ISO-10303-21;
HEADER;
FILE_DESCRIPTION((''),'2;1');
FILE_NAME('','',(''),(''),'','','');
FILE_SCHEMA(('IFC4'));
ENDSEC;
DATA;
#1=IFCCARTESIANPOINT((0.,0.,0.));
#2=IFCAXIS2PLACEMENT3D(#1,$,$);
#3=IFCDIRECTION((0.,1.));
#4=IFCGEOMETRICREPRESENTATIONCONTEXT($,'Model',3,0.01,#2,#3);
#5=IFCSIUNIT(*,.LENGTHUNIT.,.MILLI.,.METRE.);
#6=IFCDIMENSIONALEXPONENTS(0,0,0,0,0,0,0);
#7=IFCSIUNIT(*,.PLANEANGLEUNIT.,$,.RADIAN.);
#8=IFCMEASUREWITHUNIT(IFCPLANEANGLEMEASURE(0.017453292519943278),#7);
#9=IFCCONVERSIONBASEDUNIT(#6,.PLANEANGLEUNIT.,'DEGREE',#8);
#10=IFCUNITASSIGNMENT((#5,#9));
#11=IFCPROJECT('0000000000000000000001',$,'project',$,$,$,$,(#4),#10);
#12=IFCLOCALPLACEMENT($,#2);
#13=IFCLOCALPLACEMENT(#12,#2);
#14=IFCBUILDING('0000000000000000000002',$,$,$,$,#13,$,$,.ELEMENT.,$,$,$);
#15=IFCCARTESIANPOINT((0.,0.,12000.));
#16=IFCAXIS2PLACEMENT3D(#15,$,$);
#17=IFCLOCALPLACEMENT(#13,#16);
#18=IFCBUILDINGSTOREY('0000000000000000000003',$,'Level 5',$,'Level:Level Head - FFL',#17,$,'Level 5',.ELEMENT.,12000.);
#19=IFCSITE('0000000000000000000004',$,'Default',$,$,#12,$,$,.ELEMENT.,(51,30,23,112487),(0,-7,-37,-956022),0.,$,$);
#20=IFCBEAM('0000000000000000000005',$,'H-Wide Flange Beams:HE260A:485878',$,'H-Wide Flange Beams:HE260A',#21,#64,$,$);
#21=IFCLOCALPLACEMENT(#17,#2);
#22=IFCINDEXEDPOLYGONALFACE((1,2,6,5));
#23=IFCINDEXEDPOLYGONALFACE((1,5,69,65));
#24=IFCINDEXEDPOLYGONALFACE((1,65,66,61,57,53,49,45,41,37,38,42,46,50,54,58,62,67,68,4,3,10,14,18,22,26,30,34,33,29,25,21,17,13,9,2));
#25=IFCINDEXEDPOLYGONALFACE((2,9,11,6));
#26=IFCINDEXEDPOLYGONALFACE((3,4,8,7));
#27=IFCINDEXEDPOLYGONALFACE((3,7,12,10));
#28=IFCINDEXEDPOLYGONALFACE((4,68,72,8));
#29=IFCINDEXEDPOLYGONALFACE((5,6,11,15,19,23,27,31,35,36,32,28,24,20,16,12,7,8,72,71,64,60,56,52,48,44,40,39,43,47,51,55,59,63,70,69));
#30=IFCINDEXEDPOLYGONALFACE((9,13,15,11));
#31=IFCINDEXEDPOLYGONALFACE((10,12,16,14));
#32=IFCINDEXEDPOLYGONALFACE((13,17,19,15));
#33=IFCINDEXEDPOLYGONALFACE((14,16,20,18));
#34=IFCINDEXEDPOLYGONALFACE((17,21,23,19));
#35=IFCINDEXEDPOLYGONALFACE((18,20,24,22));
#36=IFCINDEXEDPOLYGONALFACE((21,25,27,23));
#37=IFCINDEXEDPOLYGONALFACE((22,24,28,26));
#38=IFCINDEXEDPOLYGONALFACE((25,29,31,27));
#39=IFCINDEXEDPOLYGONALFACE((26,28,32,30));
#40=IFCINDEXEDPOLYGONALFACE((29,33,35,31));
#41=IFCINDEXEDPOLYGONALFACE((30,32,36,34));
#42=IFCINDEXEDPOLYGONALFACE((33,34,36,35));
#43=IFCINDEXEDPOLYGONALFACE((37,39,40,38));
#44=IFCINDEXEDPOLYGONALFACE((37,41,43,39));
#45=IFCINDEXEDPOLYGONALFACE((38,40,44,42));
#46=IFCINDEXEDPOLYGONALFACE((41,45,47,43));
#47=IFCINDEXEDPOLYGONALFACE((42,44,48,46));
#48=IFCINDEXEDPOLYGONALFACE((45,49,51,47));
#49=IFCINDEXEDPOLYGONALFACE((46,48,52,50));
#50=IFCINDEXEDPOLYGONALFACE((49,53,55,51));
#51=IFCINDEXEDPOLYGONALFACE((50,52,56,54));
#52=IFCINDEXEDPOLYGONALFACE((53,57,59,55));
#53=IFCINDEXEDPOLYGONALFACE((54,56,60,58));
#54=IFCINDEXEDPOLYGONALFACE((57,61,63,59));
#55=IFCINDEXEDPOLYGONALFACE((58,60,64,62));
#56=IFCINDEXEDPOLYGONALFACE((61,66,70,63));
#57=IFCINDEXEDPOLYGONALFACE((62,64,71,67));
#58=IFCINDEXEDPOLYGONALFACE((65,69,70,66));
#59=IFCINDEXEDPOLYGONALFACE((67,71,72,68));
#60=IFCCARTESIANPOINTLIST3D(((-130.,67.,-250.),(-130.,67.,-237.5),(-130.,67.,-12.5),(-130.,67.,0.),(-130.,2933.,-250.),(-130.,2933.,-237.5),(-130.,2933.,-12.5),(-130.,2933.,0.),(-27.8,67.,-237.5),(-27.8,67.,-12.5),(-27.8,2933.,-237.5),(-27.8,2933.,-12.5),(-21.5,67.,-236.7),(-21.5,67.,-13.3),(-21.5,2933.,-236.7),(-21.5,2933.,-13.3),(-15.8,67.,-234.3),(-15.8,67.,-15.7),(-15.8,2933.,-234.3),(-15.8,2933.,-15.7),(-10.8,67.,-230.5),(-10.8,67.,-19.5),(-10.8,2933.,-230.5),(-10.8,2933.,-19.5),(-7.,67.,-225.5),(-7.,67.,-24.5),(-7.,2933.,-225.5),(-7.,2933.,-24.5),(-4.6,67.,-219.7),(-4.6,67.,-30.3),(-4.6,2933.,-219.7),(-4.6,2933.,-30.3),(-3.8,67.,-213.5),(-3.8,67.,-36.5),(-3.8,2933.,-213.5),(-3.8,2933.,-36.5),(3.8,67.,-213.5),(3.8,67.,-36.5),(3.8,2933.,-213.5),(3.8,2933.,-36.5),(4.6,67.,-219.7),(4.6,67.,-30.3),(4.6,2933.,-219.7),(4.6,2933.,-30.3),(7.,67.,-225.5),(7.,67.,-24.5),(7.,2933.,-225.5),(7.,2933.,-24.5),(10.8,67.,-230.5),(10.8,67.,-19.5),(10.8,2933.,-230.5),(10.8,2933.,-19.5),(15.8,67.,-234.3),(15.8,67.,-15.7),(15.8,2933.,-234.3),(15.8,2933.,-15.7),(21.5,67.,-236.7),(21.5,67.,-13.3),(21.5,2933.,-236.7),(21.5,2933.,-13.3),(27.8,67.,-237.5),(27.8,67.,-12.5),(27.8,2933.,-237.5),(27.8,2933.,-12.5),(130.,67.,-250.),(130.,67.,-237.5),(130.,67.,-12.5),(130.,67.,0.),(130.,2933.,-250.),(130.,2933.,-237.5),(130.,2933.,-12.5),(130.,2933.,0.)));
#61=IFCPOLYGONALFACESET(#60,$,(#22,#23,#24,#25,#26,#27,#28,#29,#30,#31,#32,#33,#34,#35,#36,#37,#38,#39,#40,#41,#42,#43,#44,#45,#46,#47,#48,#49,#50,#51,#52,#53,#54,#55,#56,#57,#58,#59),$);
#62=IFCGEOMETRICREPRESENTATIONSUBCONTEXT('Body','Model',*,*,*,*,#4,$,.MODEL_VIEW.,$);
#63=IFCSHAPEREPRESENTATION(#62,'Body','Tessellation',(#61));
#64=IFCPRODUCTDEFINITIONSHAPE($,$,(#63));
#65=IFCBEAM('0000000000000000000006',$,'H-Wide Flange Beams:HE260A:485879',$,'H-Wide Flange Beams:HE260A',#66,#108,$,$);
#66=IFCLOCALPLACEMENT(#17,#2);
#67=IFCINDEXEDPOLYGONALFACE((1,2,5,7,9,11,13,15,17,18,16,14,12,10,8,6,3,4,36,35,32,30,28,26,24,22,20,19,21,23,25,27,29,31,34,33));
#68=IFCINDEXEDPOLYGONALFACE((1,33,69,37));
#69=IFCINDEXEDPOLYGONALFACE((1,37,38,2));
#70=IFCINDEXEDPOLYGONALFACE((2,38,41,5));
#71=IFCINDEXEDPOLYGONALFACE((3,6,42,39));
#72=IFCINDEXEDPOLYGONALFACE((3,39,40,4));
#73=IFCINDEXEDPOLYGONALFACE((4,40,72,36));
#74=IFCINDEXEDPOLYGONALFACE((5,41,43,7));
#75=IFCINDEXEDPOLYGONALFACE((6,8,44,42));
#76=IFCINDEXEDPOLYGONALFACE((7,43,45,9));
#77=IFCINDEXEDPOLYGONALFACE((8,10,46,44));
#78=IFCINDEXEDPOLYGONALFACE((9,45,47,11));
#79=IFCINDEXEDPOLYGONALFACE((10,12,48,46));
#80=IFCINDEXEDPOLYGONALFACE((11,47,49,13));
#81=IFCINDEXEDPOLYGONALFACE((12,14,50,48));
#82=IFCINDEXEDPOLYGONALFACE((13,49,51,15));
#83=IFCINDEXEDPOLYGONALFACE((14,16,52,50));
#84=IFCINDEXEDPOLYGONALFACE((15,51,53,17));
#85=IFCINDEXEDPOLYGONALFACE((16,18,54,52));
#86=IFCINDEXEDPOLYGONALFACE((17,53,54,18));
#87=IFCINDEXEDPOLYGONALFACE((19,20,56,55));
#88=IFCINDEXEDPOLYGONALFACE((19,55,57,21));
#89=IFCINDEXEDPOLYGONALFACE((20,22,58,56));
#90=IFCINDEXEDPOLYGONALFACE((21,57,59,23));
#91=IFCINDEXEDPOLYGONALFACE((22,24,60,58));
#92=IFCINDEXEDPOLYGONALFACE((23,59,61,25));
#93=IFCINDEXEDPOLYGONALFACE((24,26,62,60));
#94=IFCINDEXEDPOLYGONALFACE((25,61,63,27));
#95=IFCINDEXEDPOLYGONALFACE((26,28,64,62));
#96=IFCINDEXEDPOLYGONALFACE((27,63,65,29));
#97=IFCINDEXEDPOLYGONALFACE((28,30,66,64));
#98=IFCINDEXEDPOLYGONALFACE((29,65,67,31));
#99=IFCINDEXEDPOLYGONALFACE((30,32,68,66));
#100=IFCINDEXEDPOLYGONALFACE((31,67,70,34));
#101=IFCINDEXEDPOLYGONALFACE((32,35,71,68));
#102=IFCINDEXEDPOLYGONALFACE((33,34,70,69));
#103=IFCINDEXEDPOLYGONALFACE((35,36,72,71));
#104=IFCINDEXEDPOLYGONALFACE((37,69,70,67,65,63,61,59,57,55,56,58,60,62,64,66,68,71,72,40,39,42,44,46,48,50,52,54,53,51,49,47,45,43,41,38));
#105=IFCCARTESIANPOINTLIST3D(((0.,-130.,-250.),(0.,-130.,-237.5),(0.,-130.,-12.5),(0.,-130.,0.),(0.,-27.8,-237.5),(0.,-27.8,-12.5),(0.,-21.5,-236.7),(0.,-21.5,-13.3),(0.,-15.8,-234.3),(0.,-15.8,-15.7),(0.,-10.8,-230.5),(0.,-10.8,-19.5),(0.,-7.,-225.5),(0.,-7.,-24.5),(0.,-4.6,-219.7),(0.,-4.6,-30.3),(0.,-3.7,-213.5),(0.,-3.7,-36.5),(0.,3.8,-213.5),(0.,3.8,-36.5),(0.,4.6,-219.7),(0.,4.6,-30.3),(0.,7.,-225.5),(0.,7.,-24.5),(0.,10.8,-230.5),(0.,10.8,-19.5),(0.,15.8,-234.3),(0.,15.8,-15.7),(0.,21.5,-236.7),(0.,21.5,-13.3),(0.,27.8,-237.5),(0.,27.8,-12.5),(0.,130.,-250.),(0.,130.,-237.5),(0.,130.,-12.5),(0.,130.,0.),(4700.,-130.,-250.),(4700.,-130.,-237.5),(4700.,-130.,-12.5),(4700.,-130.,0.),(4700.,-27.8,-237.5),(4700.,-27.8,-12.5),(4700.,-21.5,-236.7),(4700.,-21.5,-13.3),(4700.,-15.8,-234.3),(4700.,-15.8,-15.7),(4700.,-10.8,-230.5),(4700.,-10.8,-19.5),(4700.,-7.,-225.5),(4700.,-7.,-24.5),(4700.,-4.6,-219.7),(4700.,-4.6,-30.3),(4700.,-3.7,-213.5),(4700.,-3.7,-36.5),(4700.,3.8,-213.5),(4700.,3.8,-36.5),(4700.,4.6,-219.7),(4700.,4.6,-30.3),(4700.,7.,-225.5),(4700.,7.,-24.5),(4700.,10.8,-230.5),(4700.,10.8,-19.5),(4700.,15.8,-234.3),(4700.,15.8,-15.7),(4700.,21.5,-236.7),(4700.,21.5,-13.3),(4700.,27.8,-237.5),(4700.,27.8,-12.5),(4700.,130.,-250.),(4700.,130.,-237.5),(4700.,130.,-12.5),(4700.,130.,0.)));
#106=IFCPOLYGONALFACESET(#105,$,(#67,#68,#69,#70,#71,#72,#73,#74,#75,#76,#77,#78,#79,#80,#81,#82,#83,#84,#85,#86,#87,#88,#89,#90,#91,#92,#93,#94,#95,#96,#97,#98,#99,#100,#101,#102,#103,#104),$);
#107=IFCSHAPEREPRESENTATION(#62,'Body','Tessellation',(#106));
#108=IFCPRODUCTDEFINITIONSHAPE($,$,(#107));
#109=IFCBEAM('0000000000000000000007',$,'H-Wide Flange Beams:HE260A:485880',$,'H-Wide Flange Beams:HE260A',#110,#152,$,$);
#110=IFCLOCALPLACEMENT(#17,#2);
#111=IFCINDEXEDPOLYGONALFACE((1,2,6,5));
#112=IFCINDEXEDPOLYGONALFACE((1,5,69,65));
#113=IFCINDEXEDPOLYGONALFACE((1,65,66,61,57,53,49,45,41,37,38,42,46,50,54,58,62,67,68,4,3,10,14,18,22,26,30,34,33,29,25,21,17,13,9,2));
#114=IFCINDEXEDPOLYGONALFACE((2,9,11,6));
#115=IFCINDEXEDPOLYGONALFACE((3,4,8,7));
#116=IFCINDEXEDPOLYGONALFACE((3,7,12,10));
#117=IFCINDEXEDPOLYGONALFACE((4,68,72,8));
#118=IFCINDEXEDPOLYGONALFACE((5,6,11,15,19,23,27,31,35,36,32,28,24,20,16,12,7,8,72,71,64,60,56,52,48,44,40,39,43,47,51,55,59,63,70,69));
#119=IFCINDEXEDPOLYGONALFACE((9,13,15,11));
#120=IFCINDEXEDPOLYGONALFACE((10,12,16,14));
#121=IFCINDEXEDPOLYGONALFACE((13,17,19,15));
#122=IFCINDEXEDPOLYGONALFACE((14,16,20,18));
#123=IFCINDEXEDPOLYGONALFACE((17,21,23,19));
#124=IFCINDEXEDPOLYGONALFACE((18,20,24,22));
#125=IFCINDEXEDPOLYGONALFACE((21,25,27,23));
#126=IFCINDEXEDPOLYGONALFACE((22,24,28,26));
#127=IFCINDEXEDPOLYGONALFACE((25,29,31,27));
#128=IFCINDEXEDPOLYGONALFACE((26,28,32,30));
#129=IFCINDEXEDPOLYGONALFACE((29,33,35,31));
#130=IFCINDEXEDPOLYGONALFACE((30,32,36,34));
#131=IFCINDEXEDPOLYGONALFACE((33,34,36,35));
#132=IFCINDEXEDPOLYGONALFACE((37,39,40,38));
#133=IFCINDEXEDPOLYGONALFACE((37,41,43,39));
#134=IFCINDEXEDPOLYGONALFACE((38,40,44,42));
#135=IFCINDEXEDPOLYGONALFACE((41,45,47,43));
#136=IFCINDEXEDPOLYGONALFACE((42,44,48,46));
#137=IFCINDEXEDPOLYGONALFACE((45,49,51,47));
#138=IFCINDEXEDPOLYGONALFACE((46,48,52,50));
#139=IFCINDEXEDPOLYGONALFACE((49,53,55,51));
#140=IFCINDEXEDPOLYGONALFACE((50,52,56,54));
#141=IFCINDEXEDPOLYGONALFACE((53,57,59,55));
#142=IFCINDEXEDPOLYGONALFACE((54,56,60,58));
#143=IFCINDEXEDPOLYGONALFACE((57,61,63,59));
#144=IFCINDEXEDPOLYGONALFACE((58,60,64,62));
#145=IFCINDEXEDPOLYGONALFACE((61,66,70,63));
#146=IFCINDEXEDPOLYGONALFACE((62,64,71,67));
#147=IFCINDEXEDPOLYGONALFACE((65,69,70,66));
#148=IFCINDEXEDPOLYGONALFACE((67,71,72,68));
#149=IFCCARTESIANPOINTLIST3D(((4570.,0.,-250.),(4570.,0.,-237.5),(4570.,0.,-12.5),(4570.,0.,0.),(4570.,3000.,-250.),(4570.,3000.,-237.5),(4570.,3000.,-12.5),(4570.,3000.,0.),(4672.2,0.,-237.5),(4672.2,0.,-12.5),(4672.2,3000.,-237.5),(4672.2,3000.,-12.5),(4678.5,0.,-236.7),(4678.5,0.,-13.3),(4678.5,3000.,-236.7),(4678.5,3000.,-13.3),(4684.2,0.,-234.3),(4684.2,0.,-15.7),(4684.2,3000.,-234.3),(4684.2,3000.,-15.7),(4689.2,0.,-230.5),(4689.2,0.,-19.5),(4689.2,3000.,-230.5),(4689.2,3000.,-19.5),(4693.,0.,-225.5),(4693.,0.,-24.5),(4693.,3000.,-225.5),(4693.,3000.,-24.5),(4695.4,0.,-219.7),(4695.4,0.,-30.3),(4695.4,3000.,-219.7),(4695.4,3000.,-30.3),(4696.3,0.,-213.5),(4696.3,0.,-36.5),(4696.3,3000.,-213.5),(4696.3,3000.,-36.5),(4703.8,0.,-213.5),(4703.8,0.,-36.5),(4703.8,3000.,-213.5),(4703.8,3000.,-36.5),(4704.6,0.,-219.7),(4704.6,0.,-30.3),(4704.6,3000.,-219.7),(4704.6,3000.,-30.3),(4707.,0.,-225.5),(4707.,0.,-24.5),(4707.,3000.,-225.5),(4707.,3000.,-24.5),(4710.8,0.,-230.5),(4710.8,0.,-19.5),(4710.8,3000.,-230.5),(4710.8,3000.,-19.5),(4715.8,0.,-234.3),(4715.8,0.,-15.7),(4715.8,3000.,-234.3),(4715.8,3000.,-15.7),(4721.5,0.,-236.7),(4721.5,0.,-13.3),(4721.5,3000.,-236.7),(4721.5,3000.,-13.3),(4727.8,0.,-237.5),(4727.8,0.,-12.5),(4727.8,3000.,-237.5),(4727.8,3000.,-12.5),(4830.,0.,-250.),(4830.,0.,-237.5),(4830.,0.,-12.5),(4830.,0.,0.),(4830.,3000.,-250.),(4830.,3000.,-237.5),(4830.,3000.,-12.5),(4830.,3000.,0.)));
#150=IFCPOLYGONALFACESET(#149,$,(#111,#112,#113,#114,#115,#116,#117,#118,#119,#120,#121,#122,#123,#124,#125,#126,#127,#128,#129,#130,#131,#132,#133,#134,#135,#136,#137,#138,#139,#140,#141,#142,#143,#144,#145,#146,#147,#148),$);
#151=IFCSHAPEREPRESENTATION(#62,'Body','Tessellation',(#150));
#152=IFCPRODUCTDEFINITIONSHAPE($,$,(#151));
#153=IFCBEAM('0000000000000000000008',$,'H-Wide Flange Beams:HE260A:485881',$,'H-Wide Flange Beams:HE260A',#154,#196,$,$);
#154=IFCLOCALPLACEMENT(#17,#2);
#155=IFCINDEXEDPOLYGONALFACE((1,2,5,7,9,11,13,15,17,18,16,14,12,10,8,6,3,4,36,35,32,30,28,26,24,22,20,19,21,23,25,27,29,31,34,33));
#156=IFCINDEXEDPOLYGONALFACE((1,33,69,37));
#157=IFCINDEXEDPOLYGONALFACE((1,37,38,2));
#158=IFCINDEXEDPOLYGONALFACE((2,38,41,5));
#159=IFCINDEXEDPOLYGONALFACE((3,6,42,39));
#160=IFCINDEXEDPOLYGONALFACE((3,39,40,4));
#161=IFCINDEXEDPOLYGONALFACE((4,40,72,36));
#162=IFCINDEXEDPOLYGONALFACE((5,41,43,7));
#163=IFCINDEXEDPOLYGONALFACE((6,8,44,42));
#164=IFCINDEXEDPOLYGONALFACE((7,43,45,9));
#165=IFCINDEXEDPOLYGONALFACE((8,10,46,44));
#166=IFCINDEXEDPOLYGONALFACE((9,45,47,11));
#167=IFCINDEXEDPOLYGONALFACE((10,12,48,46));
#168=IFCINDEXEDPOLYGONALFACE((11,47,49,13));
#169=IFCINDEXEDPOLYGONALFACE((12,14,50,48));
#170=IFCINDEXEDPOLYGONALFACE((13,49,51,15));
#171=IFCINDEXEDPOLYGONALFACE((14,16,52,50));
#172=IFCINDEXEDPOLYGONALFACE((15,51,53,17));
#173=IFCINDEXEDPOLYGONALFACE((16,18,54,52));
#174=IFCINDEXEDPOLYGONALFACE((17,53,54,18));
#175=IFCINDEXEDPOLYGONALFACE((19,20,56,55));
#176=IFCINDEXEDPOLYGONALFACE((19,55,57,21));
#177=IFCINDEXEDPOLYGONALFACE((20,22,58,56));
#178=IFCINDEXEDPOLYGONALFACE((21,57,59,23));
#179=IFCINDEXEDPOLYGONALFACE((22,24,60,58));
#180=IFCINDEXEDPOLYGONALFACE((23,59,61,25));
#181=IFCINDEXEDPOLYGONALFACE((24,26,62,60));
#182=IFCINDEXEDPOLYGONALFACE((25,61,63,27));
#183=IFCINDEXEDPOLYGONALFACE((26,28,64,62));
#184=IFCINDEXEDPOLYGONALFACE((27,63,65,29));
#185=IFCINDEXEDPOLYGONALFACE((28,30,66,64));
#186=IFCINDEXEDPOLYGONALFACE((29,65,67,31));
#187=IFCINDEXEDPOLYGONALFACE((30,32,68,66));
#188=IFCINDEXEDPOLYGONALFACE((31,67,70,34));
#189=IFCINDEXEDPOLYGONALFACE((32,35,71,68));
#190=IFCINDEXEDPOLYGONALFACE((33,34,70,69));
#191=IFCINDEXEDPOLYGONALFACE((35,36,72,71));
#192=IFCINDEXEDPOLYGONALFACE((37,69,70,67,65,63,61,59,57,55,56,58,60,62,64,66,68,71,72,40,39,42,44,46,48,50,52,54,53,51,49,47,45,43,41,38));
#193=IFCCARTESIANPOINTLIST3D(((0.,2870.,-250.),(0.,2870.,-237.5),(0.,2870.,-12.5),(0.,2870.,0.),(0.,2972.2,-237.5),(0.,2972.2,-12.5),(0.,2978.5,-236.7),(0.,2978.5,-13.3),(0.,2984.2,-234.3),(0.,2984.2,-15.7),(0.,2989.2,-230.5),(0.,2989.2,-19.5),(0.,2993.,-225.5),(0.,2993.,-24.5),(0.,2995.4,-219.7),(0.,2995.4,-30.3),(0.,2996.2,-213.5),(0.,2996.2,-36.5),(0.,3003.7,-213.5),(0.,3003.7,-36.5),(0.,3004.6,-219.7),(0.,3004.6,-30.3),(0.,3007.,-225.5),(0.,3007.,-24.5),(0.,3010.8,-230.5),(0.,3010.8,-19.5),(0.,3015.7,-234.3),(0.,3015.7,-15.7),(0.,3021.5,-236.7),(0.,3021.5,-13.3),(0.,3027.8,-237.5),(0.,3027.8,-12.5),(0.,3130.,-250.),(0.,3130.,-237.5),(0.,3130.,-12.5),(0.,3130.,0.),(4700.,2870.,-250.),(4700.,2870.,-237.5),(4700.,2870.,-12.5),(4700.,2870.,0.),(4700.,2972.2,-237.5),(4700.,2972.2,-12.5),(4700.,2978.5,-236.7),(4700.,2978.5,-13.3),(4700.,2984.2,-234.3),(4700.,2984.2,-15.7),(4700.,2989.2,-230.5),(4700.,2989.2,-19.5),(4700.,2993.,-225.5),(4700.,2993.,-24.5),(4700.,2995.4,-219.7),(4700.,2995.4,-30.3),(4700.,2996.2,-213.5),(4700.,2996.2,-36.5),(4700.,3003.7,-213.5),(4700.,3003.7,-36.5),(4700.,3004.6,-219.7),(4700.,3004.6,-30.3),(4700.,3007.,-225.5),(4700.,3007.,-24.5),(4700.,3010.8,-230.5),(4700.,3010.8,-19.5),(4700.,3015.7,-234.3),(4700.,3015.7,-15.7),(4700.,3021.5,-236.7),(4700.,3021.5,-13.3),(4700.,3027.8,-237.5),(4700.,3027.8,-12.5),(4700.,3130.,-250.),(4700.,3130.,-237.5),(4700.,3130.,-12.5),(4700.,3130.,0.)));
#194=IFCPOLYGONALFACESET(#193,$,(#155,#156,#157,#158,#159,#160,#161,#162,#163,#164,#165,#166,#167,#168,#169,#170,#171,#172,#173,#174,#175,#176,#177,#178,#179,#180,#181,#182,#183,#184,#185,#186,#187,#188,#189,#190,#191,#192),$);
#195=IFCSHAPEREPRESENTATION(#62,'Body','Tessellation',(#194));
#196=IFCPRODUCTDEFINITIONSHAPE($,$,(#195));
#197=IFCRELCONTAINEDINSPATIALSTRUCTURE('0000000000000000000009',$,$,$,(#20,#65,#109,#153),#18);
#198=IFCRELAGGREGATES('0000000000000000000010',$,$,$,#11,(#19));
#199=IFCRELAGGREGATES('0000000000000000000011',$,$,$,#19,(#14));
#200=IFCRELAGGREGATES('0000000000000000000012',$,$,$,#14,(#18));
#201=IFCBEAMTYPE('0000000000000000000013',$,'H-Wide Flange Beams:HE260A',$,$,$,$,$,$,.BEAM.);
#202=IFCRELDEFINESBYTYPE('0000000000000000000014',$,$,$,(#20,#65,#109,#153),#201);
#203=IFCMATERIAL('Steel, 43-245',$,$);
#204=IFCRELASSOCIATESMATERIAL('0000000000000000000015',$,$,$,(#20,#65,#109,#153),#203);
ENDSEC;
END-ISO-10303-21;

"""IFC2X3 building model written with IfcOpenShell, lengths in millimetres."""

from ifc_helpers import new_model, entity, si_unit, converted_unit, direction, frame, frame_2d, origin, place, context, subcontext, project, spatial, i_section, extrude, material, type_object, element, save


model = new_model("IFC2X3")

# Units and contexts
model_context = context("Model", 3, precision=0.01, world=origin(), true_north=direction((0.0, 1.0)))
body_context = subcontext(model_context, "Body", "Model", "MODEL_VIEW")
ifc_project = project(units=[si_unit("LENGTHUNIT", "METRE", prefix="MILLI"), converted_unit("PLANEANGLEUNIT", "DEGREE", entity("IfcPlaneAngleMeasure", 0.017453292519943278), si_unit("PLANEANGLEUNIT", "RADIAN"), dimensions=[0, 0, 0, 0, 0, 0, 0])], contexts=[model_context])

# Site, building, storey
site_placement = place(None, origin())
site = spatial("IfcSite", under=ifc_project, at=site_placement, Name="Default", CompositionType="ELEMENT", RefLatitude=(51, 30, 23, 112487), RefLongitude=(0, -7, -37, -956022), RefElevation=0.0)
building_placement = place(site_placement, origin())
building = spatial("IfcBuilding", under=site, at=building_placement, CompositionType="ELEMENT")
storey_placement = place(building_placement, frame((0.0, 0.0, 12000.0)))
storey = spatial("IfcBuildingStorey", under=building, at=storey_placement, Name="Level 5", ObjectType="Level:Level Head - FFL", LongName="Level 5", CompositionType="ELEMENT", Elevation=12000.0)

# Beams
ifc_material = material(Name="Steel, 43-245")
beam_type_1 = type_object("IfcBeamType", Name="H-Wide Flange Beams:HE260A", PredefinedType="BEAM")
beam_1_placement = place(storey_placement, frame((0.0, 3000.0, 0.0), z_axis=(0.0, 0.0, 1.0), x_axis=(0.0, -1.0, 0.0)))
element("IfcBeam", 1, at=beam_1_placement, inside=storey, type_object=beam_type_1, material=ifc_material, Name="H-Wide Flange Beams:HE260A:485878", ObjectType="H-Wide Flange Beams:HE260A", context=body_context, shape_type="SweptSolid", body=[
    extrude(i_section(OverallWidth=260.0, OverallDepth=250.0, WebThickness=7.5, FlangeThickness=12.5, FilletRadius=24.0, at=frame_2d((0.0, 0.0), x_axis=(0.0, 1.0))), frame((67.0, 0.0, -125.0), z_axis=(1.0, 0.0, 0.0), x_axis=(0.0, 0.0, -1.0)), (0.0, 0.0, 1.0), 2866.0),
])
beam_2_placement = place(storey_placement, origin())
element("IfcBeam", 2, at=beam_2_placement, inside=storey, type_object=beam_type_1, material=ifc_material, Name="H-Wide Flange Beams:HE260A:485879", ObjectType="H-Wide Flange Beams:HE260A", context=body_context, shape_type="SweptSolid", body=[
    extrude(i_section(OverallWidth=260.0, OverallDepth=250.0, WebThickness=7.5, FlangeThickness=12.5, FilletRadius=24.0, at=frame_2d((0.0, 0.0), x_axis=(0.0, 1.0))), frame((0.0, 0.0, -125.0), z_axis=(1.0, 0.0, 0.0), x_axis=(0.0, 0.0, -1.0)), (0.0, 0.0, 1.0), 4700.0),
])
beam_3_placement = place(storey_placement, frame((4700.0, 0.0, 0.0), z_axis=(0.0, 0.0, 1.0), x_axis=(0.0, 1.0, 0.0)))
element("IfcBeam", 3, at=beam_3_placement, inside=storey, type_object=beam_type_1, material=ifc_material, Name="H-Wide Flange Beams:HE260A:485880", ObjectType="H-Wide Flange Beams:HE260A", context=body_context, shape_type="SweptSolid", body=[
    extrude(i_section(OverallWidth=260.0, OverallDepth=250.0, WebThickness=7.5, FlangeThickness=12.5, FilletRadius=24.0, at=frame_2d((0.0, 0.0), x_axis=(0.0, 1.0))), frame((0.0, 0.0, -125.0), z_axis=(1.0, 0.0, 0.0), x_axis=(0.0, 0.0, -1.0)), (0.0, 0.0, 1.0), 3000.0),
])
beam_4_placement = place(storey_placement, frame((4700.0, 3000.0, 0.0), z_axis=(0.0, 0.0, 1.0), x_axis=(-1.0, 0.0, 0.0)))
element("IfcBeam", 4, at=beam_4_placement, inside=storey, type_object=beam_type_1, material=ifc_material, Name="H-Wide Flange Beams:HE260A:485881", ObjectType="H-Wide Flange Beams:HE260A", context=body_context, shape_type="SweptSolid", body=[
    extrude(i_section(OverallWidth=260.0, OverallDepth=250.0, WebThickness=7.5, FlangeThickness=12.5, FilletRadius=24.0, at=frame_2d((0.0, 0.0), x_axis=(0.0, 1.0))), frame((0.0, 0.0, -125.0), z_axis=(1.0, 0.0, 0.0), x_axis=(0.0, 0.0, -1.0)), (0.0, 0.0, 1.0), 4700.0),
])

save(model, "model.ifc")
